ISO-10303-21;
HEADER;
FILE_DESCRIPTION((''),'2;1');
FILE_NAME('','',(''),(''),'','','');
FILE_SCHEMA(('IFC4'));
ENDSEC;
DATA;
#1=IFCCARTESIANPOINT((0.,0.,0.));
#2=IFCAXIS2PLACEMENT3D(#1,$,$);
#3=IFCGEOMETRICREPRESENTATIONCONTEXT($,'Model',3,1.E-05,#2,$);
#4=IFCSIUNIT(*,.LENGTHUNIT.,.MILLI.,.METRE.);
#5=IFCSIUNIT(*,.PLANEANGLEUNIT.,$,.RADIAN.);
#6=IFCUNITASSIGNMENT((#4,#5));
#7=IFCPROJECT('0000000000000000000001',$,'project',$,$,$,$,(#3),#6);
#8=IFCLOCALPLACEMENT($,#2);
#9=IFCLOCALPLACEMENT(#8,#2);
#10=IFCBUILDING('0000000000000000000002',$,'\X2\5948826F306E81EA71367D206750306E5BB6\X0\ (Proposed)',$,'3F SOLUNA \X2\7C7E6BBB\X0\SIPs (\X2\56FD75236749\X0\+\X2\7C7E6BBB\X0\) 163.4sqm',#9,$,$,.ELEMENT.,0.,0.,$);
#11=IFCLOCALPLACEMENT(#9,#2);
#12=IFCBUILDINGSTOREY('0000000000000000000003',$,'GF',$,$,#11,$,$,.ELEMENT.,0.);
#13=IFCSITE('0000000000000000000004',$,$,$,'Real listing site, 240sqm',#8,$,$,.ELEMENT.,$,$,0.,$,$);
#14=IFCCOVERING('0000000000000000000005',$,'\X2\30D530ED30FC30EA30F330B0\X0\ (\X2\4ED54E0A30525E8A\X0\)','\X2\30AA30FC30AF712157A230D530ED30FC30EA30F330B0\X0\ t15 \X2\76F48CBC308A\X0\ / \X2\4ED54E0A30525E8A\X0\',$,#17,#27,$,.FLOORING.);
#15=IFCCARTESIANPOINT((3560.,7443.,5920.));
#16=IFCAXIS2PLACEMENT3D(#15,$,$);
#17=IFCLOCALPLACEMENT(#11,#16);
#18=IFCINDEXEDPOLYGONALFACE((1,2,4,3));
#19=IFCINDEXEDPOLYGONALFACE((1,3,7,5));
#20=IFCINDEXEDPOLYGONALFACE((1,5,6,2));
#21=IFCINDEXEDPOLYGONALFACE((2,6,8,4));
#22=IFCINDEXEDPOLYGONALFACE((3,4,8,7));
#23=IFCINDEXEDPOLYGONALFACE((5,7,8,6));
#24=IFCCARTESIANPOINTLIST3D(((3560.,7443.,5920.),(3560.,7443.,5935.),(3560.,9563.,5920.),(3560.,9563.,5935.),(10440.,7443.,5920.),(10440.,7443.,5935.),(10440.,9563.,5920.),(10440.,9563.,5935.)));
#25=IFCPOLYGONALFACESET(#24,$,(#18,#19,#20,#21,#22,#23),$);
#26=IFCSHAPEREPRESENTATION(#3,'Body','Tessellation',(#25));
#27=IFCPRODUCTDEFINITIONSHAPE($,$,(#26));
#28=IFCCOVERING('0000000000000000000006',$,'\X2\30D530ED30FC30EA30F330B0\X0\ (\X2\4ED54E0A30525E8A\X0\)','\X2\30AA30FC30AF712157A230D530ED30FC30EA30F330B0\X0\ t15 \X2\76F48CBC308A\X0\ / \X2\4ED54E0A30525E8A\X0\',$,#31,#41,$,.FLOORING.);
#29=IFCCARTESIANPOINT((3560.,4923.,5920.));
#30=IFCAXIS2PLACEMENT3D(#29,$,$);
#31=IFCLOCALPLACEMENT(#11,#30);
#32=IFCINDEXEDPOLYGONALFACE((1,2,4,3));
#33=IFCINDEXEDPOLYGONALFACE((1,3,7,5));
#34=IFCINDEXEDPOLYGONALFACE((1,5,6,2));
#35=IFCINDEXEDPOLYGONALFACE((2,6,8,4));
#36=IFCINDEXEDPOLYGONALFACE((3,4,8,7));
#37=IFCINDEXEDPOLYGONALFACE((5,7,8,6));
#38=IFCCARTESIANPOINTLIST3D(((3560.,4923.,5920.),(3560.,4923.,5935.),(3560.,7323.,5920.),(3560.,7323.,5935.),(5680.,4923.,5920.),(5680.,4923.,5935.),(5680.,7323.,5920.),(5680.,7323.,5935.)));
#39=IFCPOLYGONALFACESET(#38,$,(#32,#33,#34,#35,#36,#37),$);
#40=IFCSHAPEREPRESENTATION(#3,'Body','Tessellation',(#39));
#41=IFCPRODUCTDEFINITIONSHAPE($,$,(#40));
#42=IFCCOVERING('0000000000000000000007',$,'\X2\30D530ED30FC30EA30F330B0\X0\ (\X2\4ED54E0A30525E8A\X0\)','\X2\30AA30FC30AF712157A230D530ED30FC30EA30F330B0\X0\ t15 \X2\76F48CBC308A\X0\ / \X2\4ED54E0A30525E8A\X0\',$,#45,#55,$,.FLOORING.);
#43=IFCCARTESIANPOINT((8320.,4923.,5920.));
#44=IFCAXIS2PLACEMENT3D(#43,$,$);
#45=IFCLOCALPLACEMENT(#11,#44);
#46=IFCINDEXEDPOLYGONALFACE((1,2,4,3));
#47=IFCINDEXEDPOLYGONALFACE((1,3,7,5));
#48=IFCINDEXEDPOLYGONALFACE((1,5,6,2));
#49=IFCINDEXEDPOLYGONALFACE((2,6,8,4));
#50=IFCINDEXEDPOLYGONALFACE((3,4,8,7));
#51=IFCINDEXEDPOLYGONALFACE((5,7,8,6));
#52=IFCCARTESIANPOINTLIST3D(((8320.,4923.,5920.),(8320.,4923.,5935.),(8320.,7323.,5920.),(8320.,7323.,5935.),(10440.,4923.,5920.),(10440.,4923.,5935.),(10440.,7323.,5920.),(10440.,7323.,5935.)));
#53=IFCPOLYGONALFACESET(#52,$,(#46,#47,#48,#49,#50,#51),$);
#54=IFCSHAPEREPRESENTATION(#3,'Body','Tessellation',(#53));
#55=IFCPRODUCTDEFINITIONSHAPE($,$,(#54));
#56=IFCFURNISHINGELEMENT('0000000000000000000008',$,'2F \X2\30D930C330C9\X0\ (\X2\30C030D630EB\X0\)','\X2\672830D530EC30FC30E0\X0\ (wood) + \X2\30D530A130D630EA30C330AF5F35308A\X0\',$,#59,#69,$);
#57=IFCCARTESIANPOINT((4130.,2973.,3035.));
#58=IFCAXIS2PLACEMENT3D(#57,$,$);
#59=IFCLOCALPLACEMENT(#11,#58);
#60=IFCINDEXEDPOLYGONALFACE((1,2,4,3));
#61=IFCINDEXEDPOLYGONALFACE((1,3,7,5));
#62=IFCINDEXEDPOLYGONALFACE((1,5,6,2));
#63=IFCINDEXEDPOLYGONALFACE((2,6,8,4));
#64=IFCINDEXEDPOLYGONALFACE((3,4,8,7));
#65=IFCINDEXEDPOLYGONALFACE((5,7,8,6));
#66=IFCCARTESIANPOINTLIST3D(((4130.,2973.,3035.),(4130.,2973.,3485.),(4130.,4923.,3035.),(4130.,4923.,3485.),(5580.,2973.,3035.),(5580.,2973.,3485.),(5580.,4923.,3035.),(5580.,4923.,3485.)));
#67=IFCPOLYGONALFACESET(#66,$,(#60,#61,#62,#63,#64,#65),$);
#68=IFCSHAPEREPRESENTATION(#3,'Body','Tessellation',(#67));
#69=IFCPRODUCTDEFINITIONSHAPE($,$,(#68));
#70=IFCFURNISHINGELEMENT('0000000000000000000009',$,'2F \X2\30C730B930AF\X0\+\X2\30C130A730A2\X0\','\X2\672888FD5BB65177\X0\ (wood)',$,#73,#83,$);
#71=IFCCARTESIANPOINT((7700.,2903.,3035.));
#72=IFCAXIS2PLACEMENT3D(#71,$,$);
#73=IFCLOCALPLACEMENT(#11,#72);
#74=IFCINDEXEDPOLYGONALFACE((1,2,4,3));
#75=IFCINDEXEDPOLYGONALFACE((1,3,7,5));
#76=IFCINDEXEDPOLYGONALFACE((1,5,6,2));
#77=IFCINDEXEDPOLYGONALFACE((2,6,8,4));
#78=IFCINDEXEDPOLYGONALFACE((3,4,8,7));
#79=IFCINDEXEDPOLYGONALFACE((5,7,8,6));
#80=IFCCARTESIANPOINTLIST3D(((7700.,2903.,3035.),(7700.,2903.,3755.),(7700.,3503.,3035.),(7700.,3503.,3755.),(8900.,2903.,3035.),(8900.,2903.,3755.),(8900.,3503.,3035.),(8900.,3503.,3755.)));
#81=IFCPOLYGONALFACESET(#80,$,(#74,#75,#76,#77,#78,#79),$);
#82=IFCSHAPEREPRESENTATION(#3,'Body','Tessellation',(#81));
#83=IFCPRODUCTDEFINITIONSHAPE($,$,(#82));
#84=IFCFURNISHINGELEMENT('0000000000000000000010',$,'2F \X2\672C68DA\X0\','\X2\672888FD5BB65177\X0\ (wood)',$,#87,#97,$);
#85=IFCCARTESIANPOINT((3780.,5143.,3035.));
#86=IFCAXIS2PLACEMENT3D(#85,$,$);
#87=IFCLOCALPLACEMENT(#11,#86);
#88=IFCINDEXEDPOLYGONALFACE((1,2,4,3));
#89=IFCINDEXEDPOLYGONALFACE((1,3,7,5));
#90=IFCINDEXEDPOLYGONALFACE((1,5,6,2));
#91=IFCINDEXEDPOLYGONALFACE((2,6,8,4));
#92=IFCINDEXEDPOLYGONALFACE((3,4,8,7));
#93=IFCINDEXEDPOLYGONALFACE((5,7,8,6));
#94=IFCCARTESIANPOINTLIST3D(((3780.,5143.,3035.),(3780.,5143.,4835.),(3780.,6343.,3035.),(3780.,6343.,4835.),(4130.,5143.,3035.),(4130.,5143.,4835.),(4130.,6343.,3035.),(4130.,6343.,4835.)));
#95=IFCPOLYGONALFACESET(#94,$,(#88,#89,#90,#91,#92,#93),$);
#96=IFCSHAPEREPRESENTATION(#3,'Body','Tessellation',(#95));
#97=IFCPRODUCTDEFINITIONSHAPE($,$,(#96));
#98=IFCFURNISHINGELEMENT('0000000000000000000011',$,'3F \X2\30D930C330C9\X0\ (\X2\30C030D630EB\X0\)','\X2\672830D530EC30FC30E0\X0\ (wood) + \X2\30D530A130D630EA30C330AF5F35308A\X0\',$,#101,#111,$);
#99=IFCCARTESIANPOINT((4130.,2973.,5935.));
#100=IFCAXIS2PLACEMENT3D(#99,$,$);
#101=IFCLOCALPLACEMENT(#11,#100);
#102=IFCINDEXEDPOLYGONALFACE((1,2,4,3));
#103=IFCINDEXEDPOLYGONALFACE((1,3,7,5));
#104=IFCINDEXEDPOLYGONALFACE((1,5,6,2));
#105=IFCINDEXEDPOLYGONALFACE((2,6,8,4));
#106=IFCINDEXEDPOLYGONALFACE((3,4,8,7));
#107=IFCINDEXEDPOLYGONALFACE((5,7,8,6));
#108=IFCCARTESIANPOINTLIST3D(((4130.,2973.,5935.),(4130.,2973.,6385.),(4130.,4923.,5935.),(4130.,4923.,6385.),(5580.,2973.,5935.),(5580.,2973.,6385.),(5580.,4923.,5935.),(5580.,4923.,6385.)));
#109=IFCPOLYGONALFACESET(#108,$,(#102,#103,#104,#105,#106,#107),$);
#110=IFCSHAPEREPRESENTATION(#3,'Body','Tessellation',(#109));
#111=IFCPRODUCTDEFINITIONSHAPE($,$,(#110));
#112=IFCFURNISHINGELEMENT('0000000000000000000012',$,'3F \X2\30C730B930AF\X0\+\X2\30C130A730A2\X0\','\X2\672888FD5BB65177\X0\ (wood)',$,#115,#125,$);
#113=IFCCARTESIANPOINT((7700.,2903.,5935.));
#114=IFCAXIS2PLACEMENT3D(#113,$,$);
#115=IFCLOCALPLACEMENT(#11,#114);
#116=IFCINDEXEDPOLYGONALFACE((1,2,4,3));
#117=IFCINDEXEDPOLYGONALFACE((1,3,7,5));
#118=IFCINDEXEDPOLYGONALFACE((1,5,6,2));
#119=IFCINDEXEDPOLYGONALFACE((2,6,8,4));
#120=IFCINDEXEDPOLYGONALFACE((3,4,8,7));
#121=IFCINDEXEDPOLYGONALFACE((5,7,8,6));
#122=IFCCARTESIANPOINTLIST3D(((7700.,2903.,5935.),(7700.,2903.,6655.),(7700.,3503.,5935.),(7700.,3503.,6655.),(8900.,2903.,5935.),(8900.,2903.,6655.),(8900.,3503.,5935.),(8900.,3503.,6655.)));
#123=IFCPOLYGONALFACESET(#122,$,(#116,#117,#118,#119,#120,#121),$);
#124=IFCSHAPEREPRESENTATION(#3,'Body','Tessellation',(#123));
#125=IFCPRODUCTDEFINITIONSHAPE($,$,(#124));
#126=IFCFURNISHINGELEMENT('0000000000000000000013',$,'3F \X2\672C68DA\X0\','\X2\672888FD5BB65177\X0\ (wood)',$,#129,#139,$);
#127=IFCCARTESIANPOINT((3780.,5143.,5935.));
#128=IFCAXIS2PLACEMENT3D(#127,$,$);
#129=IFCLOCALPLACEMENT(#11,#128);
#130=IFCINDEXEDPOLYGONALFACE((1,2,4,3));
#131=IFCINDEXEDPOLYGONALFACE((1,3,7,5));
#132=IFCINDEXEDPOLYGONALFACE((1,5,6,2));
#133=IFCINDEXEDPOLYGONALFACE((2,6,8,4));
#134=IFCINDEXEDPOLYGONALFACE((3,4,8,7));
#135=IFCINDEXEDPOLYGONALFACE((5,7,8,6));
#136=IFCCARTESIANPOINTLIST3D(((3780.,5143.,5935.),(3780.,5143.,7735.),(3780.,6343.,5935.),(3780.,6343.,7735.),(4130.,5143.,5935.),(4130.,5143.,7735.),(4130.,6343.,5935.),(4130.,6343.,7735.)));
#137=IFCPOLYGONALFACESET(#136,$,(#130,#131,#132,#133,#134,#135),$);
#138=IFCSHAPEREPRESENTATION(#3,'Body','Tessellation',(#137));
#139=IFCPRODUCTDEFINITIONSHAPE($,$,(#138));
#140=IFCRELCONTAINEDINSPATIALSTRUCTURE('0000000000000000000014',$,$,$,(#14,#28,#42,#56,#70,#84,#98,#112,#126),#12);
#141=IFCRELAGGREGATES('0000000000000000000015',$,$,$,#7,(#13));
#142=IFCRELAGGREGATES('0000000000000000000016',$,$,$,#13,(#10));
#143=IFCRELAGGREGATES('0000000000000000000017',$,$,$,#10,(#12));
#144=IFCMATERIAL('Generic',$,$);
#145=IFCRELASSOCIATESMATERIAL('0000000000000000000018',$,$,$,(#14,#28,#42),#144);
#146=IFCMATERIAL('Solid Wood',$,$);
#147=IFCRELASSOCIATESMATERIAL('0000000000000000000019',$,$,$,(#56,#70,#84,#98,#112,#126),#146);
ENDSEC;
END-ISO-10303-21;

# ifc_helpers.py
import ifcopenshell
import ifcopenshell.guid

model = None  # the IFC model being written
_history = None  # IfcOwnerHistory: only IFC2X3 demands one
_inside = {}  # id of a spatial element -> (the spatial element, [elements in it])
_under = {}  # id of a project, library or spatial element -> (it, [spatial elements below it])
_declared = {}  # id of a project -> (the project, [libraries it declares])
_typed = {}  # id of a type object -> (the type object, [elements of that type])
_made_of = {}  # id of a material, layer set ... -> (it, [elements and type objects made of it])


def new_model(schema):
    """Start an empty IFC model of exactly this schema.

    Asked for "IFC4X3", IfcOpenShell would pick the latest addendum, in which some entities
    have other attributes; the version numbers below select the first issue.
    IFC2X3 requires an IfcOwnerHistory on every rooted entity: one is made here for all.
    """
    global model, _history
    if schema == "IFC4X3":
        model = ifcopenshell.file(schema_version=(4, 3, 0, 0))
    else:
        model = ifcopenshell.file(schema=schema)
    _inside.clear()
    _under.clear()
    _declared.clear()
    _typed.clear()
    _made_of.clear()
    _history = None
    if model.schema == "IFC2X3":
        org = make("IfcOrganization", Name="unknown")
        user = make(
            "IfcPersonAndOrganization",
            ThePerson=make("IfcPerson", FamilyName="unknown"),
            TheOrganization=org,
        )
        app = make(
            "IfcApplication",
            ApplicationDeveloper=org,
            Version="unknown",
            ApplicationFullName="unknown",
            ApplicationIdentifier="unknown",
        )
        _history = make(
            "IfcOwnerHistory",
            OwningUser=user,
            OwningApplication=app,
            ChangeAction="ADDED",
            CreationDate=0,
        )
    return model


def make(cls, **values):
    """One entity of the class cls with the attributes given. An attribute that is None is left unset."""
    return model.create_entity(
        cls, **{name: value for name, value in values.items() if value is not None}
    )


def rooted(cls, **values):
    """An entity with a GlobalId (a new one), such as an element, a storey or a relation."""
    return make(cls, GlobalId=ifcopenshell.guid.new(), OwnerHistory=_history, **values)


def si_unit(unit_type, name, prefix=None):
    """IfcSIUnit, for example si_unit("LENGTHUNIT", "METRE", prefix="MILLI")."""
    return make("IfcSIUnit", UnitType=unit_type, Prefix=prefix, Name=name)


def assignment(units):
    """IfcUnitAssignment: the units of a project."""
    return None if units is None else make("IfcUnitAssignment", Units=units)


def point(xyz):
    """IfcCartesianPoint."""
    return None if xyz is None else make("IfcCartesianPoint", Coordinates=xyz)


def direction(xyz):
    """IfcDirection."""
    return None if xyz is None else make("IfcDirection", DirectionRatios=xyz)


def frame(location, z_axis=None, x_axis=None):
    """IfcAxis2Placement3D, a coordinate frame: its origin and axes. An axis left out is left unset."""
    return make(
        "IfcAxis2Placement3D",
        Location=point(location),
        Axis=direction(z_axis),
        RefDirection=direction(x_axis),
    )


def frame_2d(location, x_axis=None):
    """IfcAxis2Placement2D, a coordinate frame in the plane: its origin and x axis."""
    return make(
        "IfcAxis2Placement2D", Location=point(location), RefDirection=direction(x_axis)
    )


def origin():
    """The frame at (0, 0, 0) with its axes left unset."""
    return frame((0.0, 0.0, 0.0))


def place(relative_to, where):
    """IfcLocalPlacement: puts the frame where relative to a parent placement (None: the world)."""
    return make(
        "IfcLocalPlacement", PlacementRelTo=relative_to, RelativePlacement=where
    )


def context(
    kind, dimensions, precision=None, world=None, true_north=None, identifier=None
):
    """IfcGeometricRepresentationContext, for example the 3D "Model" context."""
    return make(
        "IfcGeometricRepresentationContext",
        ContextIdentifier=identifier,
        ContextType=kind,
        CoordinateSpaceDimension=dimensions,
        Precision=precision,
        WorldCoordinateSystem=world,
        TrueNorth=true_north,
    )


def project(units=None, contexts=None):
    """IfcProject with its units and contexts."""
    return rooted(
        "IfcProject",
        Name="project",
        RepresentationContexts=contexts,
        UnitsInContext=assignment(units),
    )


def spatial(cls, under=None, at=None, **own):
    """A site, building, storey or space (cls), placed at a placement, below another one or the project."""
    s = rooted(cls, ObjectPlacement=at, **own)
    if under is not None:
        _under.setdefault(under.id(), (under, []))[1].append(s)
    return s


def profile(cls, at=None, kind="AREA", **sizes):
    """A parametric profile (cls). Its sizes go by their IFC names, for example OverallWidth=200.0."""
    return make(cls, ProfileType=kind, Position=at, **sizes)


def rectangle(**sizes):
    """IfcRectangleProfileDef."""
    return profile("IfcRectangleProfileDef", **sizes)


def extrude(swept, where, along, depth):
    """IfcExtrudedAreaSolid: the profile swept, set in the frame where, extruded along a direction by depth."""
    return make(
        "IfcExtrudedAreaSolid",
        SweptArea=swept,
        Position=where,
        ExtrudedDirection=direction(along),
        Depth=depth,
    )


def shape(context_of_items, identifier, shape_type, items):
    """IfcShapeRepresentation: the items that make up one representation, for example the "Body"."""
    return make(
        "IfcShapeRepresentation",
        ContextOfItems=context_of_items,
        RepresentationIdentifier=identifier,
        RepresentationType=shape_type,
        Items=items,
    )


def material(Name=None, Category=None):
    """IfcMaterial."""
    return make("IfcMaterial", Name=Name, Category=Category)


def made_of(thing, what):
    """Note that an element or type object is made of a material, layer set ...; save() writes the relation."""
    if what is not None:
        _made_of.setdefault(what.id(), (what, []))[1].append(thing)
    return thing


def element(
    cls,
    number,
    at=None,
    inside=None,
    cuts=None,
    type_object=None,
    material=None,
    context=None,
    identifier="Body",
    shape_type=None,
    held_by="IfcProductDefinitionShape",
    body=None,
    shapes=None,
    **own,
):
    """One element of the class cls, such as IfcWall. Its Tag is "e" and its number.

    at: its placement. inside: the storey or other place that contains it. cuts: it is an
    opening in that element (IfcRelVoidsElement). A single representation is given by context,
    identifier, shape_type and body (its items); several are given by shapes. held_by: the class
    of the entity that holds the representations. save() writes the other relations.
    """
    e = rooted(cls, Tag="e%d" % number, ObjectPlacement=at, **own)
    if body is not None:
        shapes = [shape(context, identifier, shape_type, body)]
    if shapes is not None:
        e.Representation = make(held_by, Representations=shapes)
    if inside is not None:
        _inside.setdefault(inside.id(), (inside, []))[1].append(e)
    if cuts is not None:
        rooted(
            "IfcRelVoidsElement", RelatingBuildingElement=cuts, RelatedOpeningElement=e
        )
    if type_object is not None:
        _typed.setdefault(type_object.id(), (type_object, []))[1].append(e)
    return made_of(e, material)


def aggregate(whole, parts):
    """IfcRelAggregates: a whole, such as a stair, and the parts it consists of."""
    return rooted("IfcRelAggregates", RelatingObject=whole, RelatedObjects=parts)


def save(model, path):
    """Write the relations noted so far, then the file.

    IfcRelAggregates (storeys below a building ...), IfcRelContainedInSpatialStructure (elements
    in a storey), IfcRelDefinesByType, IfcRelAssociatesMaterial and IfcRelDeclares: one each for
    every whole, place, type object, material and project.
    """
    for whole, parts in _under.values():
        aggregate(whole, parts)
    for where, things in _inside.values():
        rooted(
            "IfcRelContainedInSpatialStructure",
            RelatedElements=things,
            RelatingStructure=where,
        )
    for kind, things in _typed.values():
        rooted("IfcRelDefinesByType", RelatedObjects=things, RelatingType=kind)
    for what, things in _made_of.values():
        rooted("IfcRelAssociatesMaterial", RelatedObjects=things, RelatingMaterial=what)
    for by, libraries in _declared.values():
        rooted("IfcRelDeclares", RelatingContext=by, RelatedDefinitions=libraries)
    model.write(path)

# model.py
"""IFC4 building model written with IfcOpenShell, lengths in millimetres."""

from ifc_helpers import new_model, si_unit, frame, frame_2d, origin, place, context, project, spatial, rectangle, extrude, material, element, save


model = new_model("IFC4")

# Units and contexts
model_context = context("Model", 3, precision=1e-05, world=origin())
ifc_project = project(units=[si_unit("LENGTHUNIT", "METRE", prefix="MILLI"), si_unit("PLANEANGLEUNIT", "RADIAN")], contexts=[model_context])

# Site, building, storey
site_placement = place(None, origin())
site = spatial("IfcSite", under=ifc_project, at=site_placement, ObjectType="Real listing site, 240sqm", CompositionType="ELEMENT", RefElevation=0.0)
building_placement = place(site_placement, origin())
building = spatial("IfcBuilding", under=site, at=building_placement, Name="奈良の自然素材の家 (Proposed)", ObjectType="3F SOLUNA 籾殻SIPs (国産杉+籾殻) 163.4sqm", CompositionType="ELEMENT", ElevationOfRefHeight=0.0, ElevationOfTerrain=0.0)
storey_placement = place(building_placement, origin())
storey = spatial("IfcBuildingStorey", under=building, at=storey_placement, Name="GF", CompositionType="ELEMENT", Elevation=0.0)

# Shared definitions
ifc_material_1 = material(Name="Solid Wood")

# Shared definitions
ifc_material_2 = material(Name="Generic")

# Coverings
covering_1_placement = place(storey_placement, frame((3560.0, 7443.0, 5920.0)))
element("IfcCovering", 1, at=covering_1_placement, inside=storey, material=ifc_material_2, Name="フローリング (仕上げ床)", Description="オーク無垢フローリング t15 直貼り / 仕上げ床", PredefinedType="FLOORING", context=model_context, shape_type="SweptSolid", body=[
    extrude(rectangle(XDim=6880.0, YDim=2120.0, at=frame_2d((3440.0, 1060.0))), frame((3560.0, 7443.0, 5920.0)), (0.0, 0.0, 1.0), 15.0),
])
covering_2_placement = place(storey_placement, frame((3560.0, 4923.0, 5920.0)))
element("IfcCovering", 2, at=covering_2_placement, inside=storey, material=ifc_material_2, Name="フローリング (仕上げ床)", Description="オーク無垢フローリング t15 直貼り / 仕上げ床", PredefinedType="FLOORING", context=model_context, shape_type="SweptSolid", body=[
    extrude(rectangle(XDim=2120.0, YDim=2400.0, at=frame_2d((1060.0, 1200.0))), frame((3560.0, 4923.0, 5920.0)), (0.0, 0.0, 1.0), 15.0),
])
covering_3_placement = place(storey_placement, frame((8320.0, 4923.0, 5920.0)))
element("IfcCovering", 3, at=covering_3_placement, inside=storey, material=ifc_material_2, Name="フローリング (仕上げ床)", Description="オーク無垢フローリング t15 直貼り / 仕上げ床", PredefinedType="FLOORING", context=model_context, shape_type="SweptSolid", body=[
    extrude(rectangle(XDim=2120.0, YDim=2400.0, at=frame_2d((1060.0, 1200.0))), frame((8320.0, 4923.0, 5920.0)), (0.0, 0.0, 1.0), 15.0),
])

# Furnishing elements
furnishing_1_placement = place(storey_placement, frame((4130.0, 2973.0, 3035.0)))
element("IfcFurnishingElement", 4, at=furnishing_1_placement, inside=storey, material=ifc_material_1, Name="2F ベッド (ダブル)", Description="木フレーム (wood) + ファブリック張り", context=model_context, shape_type="SweptSolid", body=[
    extrude(rectangle(XDim=1450.0, YDim=1950.0, at=frame_2d((725.0, 975.0))), frame((4130.0, 2973.0, 3035.0)), (0.0, 0.0, 1.0), 450.0),
])
furnishing_2_placement = place(storey_placement, frame((7700.0, 2903.0, 3035.0)))
element("IfcFurnishingElement", 5, at=furnishing_2_placement, inside=storey, material=ifc_material_1, Name="2F デスク+チェア", Description="木製家具 (wood)", context=model_context, shape_type="SweptSolid", body=[
    extrude(rectangle(XDim=1200.0, YDim=600.0, at=frame_2d((600.0, 300.0))), frame((7700.0, 2903.0, 3035.0)), (0.0, 0.0, 1.0), 720.0),
])
furnishing_3_placement = place(storey_placement, frame((3780.0, 5143.0, 3035.0)))
element("IfcFurnishingElement", 6, at=furnishing_3_placement, inside=storey, material=ifc_material_1, Name="2F 本棚", Description="木製家具 (wood)", context=model_context, shape_type="SweptSolid", body=[
    extrude(rectangle(XDim=350.0, YDim=1200.0, at=frame_2d((175.0, 600.0))), frame((3780.0, 5143.0, 3035.0)), (0.0, 0.0, 1.0), 1800.0),
])
furnishing_4_placement = place(storey_placement, frame((4130.0, 2973.0, 5935.0)))
element("IfcFurnishingElement", 7, at=furnishing_4_placement, inside=storey, material=ifc_material_1, Name="3F ベッド (ダブル)", Description="木フレーム (wood) + ファブリック張り", context=model_context, shape_type="SweptSolid", body=[
    extrude(rectangle(XDim=1450.0, YDim=1950.0, at=frame_2d((725.0, 975.0))), frame((4130.0, 2973.0, 5935.0)), (0.0, 0.0, 1.0), 450.0),
])
furnishing_5_placement = place(storey_placement, frame((7700.0, 2903.0, 5935.0)))
element("IfcFurnishingElement", 8, at=furnishing_5_placement, inside=storey, material=ifc_material_1, Name="3F デスク+チェア", Description="木製家具 (wood)", context=model_context, shape_type="SweptSolid", body=[
    extrude(rectangle(XDim=1200.0, YDim=600.0, at=frame_2d((600.0, 300.0))), frame((7700.0, 2903.0, 5935.0)), (0.0, 0.0, 1.0), 720.0),
])
furnishing_6_placement = place(storey_placement, frame((3780.0, 5143.0, 5935.0)))
element("IfcFurnishingElement", 9, at=furnishing_6_placement, inside=storey, material=ifc_material_1, Name="3F 本棚", Description="木製家具 (wood)", context=model_context, shape_type="SweptSolid", body=[
    extrude(rectangle(XDim=350.0, YDim=1200.0, at=frame_2d((175.0, 600.0))), frame((3780.0, 5143.0, 5935.0)), (0.0, 0.0, 1.0), 1800.0),
])

save(model, "model.ifc")
